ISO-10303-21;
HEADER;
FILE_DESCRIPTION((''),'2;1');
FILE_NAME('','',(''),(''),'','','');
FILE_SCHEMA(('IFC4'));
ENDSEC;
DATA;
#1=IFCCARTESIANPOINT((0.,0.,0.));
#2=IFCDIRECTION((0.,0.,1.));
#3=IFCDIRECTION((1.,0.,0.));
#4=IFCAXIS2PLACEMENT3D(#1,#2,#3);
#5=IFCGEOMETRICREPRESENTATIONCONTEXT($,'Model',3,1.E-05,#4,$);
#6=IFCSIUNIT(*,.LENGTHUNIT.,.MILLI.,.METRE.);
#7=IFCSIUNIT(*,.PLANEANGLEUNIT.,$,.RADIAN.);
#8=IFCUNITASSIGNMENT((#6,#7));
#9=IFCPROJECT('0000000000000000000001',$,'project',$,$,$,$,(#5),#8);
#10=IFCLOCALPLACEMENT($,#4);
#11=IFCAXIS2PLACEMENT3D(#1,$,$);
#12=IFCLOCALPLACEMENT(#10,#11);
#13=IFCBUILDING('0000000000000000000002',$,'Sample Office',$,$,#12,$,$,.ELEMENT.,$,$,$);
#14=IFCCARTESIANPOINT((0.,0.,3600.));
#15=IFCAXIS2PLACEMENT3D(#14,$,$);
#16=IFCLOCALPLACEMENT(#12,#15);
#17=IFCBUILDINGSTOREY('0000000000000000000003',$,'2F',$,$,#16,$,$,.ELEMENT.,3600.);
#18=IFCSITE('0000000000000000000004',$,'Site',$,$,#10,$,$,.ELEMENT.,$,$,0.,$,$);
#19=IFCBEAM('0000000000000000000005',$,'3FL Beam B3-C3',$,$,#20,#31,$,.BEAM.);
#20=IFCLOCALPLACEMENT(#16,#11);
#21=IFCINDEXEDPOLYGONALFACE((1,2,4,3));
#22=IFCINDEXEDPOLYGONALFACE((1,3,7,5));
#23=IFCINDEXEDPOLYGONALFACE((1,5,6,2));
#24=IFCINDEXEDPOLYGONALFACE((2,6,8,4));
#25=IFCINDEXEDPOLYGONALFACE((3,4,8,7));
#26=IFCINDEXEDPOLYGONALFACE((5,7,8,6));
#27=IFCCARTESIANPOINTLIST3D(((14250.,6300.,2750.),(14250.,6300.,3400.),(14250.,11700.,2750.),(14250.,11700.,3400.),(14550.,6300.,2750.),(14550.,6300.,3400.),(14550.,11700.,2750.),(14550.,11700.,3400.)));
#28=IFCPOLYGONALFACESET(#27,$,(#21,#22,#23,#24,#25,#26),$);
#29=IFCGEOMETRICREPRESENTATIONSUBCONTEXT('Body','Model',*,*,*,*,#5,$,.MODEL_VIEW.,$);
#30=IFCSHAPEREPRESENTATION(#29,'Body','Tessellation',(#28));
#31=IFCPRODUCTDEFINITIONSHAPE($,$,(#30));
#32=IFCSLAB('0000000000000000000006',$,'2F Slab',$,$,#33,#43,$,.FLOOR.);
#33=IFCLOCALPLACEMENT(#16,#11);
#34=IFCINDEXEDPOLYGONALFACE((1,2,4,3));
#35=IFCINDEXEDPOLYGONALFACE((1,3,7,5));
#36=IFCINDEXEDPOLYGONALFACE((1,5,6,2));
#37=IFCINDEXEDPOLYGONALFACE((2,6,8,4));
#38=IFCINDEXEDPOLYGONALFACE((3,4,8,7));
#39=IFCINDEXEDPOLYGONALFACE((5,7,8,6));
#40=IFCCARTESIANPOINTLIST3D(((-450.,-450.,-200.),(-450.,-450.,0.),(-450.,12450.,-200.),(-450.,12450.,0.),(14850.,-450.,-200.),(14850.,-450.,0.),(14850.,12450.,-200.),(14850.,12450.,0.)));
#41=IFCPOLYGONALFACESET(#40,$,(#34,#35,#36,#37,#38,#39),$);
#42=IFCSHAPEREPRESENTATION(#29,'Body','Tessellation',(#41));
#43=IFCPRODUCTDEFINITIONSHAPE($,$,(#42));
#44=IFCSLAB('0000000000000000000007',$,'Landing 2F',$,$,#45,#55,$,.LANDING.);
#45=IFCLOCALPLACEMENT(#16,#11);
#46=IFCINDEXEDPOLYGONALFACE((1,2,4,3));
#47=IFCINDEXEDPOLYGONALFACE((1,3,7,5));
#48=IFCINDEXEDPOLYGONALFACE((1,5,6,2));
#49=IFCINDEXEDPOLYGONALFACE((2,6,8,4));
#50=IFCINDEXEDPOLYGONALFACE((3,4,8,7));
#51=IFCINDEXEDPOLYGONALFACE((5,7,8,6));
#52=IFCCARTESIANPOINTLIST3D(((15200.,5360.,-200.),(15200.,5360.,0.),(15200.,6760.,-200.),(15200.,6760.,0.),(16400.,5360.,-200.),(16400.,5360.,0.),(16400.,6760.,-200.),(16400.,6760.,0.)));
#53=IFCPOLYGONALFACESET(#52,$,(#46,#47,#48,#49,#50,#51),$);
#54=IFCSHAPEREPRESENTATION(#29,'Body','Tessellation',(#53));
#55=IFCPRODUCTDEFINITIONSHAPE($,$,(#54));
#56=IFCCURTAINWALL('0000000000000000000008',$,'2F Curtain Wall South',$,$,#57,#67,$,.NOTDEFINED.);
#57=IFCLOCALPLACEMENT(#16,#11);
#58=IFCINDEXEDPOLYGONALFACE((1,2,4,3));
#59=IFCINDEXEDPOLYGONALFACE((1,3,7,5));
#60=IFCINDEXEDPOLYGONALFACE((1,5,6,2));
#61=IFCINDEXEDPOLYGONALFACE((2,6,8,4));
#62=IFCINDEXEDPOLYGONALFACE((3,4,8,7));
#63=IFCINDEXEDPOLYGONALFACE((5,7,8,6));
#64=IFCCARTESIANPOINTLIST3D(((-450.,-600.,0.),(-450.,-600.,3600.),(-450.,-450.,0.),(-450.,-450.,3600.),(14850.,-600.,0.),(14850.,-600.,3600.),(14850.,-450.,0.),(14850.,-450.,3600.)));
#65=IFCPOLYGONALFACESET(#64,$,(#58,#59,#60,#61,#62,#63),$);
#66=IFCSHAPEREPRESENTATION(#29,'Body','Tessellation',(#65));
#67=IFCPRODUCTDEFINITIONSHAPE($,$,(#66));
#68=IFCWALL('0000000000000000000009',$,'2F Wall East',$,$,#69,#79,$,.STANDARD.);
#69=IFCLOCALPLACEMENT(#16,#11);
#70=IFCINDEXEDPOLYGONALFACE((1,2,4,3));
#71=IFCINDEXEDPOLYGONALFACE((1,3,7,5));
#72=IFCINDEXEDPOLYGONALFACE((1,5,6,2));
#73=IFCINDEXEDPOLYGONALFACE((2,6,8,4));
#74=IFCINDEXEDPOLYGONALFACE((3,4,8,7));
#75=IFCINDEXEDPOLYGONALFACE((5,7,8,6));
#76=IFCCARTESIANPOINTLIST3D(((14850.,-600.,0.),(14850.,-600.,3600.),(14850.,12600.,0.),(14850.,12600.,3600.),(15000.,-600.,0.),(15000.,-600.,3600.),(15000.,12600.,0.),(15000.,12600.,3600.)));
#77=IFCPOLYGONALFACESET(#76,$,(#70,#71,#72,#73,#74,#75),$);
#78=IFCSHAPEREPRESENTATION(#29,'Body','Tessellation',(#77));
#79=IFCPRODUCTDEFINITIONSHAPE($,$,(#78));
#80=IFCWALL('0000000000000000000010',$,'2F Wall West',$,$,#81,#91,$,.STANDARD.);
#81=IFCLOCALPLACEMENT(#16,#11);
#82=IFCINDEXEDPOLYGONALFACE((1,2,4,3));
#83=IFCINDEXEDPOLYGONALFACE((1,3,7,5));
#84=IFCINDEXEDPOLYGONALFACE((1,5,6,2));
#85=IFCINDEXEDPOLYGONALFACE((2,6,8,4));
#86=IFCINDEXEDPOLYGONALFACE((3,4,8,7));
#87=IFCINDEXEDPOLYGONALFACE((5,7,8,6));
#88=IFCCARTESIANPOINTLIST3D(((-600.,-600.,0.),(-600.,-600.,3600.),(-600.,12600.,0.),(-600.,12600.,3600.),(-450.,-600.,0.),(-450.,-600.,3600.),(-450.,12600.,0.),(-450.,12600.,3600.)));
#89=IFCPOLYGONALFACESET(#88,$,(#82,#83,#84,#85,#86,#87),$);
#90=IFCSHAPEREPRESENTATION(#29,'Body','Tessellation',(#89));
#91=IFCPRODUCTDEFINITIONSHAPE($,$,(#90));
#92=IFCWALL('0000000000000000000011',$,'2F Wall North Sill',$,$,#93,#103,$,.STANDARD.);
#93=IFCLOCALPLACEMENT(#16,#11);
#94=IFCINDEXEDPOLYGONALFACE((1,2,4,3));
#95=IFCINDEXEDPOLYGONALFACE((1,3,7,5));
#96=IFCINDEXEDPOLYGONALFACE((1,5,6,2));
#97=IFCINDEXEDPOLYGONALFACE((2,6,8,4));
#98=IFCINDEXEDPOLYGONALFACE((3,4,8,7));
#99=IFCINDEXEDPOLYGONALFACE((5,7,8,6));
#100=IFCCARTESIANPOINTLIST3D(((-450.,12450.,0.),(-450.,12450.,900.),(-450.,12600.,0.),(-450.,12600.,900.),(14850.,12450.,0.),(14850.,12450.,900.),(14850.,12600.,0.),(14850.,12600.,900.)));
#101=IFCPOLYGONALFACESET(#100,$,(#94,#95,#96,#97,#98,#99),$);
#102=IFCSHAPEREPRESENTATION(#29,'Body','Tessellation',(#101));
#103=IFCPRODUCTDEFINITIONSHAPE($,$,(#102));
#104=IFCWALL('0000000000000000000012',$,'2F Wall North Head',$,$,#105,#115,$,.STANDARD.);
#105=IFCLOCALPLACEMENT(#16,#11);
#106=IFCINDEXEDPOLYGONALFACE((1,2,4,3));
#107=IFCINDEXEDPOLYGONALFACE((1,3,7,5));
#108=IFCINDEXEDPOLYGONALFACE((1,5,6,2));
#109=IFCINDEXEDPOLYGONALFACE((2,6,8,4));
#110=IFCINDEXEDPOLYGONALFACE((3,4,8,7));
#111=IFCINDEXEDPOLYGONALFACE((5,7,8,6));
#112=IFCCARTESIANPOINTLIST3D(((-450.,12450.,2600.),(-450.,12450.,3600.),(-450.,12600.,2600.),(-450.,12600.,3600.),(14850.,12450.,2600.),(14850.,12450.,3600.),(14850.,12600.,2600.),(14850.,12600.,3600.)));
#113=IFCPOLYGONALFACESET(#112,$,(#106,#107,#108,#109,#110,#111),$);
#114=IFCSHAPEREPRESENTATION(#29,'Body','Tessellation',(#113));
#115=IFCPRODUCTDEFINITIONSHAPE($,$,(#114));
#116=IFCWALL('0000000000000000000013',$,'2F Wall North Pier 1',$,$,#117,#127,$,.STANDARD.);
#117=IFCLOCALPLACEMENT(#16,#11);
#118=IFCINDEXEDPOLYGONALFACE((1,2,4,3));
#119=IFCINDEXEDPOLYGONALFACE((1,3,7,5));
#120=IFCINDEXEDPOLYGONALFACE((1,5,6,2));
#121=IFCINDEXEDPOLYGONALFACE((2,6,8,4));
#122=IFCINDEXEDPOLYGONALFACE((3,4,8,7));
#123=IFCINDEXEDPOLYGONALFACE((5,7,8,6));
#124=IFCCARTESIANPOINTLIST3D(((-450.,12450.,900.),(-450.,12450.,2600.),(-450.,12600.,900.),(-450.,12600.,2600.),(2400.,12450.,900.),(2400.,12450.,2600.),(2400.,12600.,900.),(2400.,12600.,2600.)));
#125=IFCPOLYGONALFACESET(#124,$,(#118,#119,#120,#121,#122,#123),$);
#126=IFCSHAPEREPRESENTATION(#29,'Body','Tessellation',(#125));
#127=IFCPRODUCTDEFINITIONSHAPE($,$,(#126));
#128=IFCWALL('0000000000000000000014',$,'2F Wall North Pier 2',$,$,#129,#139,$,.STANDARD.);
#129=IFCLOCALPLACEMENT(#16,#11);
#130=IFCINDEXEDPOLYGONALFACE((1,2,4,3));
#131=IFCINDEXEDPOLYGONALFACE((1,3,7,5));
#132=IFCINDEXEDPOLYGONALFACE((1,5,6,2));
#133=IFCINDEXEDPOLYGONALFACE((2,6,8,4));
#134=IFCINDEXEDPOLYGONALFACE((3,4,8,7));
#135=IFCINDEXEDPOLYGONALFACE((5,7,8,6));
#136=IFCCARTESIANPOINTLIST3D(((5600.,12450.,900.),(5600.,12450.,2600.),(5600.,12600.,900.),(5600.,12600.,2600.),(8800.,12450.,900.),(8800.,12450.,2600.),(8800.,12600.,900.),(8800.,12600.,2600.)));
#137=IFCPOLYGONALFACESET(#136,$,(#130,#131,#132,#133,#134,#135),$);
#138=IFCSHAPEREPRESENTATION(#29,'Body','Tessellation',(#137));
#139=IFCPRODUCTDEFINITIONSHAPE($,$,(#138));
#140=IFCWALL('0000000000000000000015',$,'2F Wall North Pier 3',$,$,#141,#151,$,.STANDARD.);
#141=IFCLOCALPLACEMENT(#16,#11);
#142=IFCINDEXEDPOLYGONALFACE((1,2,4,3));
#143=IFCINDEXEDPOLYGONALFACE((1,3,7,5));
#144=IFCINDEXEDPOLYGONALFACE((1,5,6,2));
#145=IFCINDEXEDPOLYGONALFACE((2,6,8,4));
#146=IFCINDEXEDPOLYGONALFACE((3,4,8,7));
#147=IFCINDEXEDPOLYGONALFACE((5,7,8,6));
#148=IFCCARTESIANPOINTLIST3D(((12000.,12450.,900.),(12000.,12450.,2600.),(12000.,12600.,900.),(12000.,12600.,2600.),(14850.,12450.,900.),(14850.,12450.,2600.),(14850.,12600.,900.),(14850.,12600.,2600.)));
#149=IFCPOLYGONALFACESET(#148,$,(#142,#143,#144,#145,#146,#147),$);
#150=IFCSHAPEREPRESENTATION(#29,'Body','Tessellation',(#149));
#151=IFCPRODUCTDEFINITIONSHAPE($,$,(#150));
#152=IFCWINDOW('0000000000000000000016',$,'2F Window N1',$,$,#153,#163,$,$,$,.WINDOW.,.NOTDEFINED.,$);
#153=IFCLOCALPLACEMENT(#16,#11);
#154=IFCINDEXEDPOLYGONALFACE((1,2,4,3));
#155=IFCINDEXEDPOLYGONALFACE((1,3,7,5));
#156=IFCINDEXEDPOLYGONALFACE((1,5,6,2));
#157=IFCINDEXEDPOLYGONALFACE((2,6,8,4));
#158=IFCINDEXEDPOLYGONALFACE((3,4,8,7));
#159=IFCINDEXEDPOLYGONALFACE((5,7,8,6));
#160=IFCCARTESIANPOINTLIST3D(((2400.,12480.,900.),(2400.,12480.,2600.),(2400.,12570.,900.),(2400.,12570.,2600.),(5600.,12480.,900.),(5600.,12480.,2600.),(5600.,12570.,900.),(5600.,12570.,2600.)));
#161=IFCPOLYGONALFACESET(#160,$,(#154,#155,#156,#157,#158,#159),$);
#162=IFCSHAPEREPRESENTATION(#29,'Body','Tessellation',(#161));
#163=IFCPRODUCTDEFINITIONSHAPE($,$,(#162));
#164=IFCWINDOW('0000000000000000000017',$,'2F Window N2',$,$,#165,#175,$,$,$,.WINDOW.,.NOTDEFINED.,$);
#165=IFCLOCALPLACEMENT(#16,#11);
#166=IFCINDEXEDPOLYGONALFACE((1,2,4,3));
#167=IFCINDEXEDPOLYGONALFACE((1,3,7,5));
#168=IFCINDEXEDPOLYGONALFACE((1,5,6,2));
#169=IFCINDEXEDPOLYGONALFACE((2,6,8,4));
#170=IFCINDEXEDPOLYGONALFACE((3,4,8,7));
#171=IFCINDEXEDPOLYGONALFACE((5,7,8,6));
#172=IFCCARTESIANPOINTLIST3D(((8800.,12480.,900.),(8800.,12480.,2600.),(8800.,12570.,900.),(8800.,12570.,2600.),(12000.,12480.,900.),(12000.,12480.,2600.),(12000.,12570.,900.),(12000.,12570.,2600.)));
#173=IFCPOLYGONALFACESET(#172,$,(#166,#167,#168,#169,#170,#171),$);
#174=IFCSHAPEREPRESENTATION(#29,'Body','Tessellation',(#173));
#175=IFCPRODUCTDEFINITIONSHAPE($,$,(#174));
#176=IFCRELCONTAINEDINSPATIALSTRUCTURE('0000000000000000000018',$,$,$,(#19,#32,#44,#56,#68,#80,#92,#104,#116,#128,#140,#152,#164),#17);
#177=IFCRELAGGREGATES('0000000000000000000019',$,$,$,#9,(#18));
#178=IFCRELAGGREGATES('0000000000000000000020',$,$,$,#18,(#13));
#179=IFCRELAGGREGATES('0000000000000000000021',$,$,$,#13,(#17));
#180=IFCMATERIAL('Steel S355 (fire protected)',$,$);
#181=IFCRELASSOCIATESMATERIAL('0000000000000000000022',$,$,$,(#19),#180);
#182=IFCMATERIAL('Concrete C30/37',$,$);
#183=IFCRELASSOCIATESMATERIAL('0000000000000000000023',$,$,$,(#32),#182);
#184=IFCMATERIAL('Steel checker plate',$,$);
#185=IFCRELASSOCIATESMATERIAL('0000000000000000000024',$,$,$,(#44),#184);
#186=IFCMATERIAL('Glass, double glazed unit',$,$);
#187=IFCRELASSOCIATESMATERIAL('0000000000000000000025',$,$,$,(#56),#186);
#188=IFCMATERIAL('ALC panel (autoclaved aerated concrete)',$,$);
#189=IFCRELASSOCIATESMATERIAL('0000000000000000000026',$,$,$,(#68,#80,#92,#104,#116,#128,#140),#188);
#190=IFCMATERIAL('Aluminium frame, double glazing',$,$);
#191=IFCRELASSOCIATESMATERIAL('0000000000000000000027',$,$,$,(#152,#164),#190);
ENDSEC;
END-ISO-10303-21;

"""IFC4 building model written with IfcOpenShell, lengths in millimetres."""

from ifc_helpers import new_model, si_unit, frame, origin, origin_with_axes, origin_2d, place, context, subcontext, project, spatial, rectangle, extrude, material, element, save


model = new_model("IFC4")

# Units and contexts
model_context = context("Model", 3, precision=1e-05, world=origin_with_axes())
body_context = subcontext(model_context, "Body", "Model", "MODEL_VIEW")
ifc_project = project(units=[si_unit("LENGTHUNIT", "METRE", prefix="MILLI"), si_unit("PLANEANGLEUNIT", "RADIAN")], contexts=[model_context])

# Site, building, storey
site_placement = place(None, origin_with_axes())
site = spatial("IfcSite", under=ifc_project, at=site_placement, Name="Site", CompositionType="ELEMENT", RefElevation=0.0)
building_placement = place(site_placement, origin())
building = spatial("IfcBuilding", under=site, at=building_placement, Name="Sample Office", CompositionType="ELEMENT")
storey_placement = place(building_placement, frame((0.0, 0.0, 3600.0)))
storey = spatial("IfcBuildingStorey", under=building, at=storey_placement, Name="2F", CompositionType="ELEMENT", Elevation=3600.0)

# Shared definitions
ifc_material_1 = material(Name="Concrete C30/37")

# Beam
ifc_material_2 = material(Name="Steel S355 (fire protected)")
for number, where, name in (
    (1, (14400.0, 9000.0, 2750.0), "3FL Beam B3-C3"),
):
    element("IfcBeam", number, at=place(storey_placement, frame(where)), inside=storey, material=ifc_material_2, Name=name, PredefinedType="BEAM", context=body_context, shape_type="SweptSolid", body=[
        extrude(rectangle(XDim=300.0, YDim=5400.0, at=origin_2d()), origin(), (0.0, 0.0, 1.0), 650.0),
    ])

# Slabs
slab_1_placement = place(storey_placement, frame((7200.0, 6000.0, -200.0)))
element("IfcSlab", 2, at=slab_1_placement, inside=storey, material=ifc_material_1, Name="2F Slab", PredefinedType="FLOOR", context=body_context, shape_type="SweptSolid", body=[
    extrude(rectangle(XDim=15300.0, YDim=12900.0, at=origin_2d()), origin(), (0.0, 0.0, 1.0), 200.0),
])
ifc_material_3 = material(Name="Steel checker plate")
slab_2_placement = place(storey_placement, frame((15800.0, 6060.0, -200.0)))
element("IfcSlab", 3, at=slab_2_placement, inside=storey, material=ifc_material_3, Name="Landing 2F", PredefinedType="LANDING", context=body_context, shape_type="SweptSolid", body=[
    extrude(rectangle(XDim=1200.0, YDim=1400.0, at=origin_2d()), origin(), (0.0, 0.0, 1.0), 200.0),
])

# Curtain wall
ifc_material_4 = material(Name="Glass, double glazed unit")
curtain_wall_placement = place(storey_placement, frame((7200.0, -525.0, 0.0)))
element("IfcCurtainWall", 4, at=curtain_wall_placement, inside=storey, material=ifc_material_4, Name="2F Curtain Wall South", PredefinedType="NOTDEFINED", context=body_context, shape_type="SweptSolid", body=[
    extrude(rectangle(XDim=15300.0, YDim=150.0, at=origin_2d()), origin(), (0.0, 0.0, 1.0), 3600.0),
])

# Walls
ifc_material_5 = material(Name="ALC panel (autoclaved aerated concrete)")
for number, where, name in (
    (5, (14925.0, 6000.0, 0.0), "2F Wall East"),
    (6, (-525.0, 6000.0, 0.0), "2F Wall West"),
):
    element("IfcWall", number, at=place(storey_placement, frame(where)), inside=storey, material=ifc_material_5, Name=name, PredefinedType="STANDARD", context=body_context, shape_type="SweptSolid", body=[
        extrude(rectangle(XDim=150.0, YDim=13200.0, at=origin_2d()), origin(), (0.0, 0.0, 1.0), 3600.0),
    ])
wall_1_placement = place(storey_placement, frame((7200.0, 12525.0, 0.0)))
element("IfcWall", 7, at=wall_1_placement, inside=storey, material=ifc_material_5, Name="2F Wall North Sill", PredefinedType="STANDARD", context=body_context, shape_type="SweptSolid", body=[
    extrude(rectangle(XDim=15300.0, YDim=150.0, at=origin_2d()), origin(), (0.0, 0.0, 1.0), 900.0),
])
wall_2_placement = place(storey_placement, frame((7200.0, 12525.0, 2600.0)))
element("IfcWall", 8, at=wall_2_placement, inside=storey, material=ifc_material_5, Name="2F Wall North Head", PredefinedType="STANDARD", context=body_context, shape_type="SweptSolid", body=[
    extrude(rectangle(XDim=15300.0, YDim=150.0, at=origin_2d()), origin(), (0.0, 0.0, 1.0), 1000.0),
])
wall_3_placement = place(storey_placement, frame((975.0, 12525.0, 900.0)))
element("IfcWall", 9, at=wall_3_placement, inside=storey, material=ifc_material_5, Name="2F Wall North Pier 1", PredefinedType="STANDARD", context=body_context, shape_type="SweptSolid", body=[
    extrude(rectangle(XDim=2850.0, YDim=150.0, at=origin_2d()), origin(), (0.0, 0.0, 1.0), 1700.0),
])
wall_4_placement = place(storey_placement, frame((7200.0, 12525.0, 900.0)))
element("IfcWall", 10, at=wall_4_placement, inside=storey, material=ifc_material_5, Name="2F Wall North Pier 2", PredefinedType="STANDARD", context=body_context, shape_type="SweptSolid", body=[
    extrude(rectangle(XDim=3200.0, YDim=150.0, at=origin_2d()), origin(), (0.0, 0.0, 1.0), 1700.0),
])
wall_5_placement = place(storey_placement, frame((13425.0, 12525.0, 900.0)))
element("IfcWall", 11, at=wall_5_placement, inside=storey, material=ifc_material_5, Name="2F Wall North Pier 3", PredefinedType="STANDARD", context=body_context, shape_type="SweptSolid", body=[
    extrude(rectangle(XDim=2850.0, YDim=150.0, at=origin_2d()), origin(), (0.0, 0.0, 1.0), 1700.0),
])

# Windows
ifc_material_6 = material(Name="Aluminium frame, double glazing")
for number, where, name in (
    (12, (4000.0, 12525.0, 900.0), "2F Window N1"),
    (13, (10400.0, 12525.0, 900.0), "2F Window N2"),
):
    element("IfcWindow", number, at=place(storey_placement, frame(where)), inside=storey, material=ifc_material_6, Name=name, PartitioningType="NOTDEFINED", PredefinedType="WINDOW", context=body_context, shape_type="SweptSolid", body=[
        extrude(rectangle(XDim=3200.0, YDim=90.0, at=origin_2d()), origin(), (0.0, 0.0, 1.0), 1700.0),
    ])

save(model, "model.ifc")
